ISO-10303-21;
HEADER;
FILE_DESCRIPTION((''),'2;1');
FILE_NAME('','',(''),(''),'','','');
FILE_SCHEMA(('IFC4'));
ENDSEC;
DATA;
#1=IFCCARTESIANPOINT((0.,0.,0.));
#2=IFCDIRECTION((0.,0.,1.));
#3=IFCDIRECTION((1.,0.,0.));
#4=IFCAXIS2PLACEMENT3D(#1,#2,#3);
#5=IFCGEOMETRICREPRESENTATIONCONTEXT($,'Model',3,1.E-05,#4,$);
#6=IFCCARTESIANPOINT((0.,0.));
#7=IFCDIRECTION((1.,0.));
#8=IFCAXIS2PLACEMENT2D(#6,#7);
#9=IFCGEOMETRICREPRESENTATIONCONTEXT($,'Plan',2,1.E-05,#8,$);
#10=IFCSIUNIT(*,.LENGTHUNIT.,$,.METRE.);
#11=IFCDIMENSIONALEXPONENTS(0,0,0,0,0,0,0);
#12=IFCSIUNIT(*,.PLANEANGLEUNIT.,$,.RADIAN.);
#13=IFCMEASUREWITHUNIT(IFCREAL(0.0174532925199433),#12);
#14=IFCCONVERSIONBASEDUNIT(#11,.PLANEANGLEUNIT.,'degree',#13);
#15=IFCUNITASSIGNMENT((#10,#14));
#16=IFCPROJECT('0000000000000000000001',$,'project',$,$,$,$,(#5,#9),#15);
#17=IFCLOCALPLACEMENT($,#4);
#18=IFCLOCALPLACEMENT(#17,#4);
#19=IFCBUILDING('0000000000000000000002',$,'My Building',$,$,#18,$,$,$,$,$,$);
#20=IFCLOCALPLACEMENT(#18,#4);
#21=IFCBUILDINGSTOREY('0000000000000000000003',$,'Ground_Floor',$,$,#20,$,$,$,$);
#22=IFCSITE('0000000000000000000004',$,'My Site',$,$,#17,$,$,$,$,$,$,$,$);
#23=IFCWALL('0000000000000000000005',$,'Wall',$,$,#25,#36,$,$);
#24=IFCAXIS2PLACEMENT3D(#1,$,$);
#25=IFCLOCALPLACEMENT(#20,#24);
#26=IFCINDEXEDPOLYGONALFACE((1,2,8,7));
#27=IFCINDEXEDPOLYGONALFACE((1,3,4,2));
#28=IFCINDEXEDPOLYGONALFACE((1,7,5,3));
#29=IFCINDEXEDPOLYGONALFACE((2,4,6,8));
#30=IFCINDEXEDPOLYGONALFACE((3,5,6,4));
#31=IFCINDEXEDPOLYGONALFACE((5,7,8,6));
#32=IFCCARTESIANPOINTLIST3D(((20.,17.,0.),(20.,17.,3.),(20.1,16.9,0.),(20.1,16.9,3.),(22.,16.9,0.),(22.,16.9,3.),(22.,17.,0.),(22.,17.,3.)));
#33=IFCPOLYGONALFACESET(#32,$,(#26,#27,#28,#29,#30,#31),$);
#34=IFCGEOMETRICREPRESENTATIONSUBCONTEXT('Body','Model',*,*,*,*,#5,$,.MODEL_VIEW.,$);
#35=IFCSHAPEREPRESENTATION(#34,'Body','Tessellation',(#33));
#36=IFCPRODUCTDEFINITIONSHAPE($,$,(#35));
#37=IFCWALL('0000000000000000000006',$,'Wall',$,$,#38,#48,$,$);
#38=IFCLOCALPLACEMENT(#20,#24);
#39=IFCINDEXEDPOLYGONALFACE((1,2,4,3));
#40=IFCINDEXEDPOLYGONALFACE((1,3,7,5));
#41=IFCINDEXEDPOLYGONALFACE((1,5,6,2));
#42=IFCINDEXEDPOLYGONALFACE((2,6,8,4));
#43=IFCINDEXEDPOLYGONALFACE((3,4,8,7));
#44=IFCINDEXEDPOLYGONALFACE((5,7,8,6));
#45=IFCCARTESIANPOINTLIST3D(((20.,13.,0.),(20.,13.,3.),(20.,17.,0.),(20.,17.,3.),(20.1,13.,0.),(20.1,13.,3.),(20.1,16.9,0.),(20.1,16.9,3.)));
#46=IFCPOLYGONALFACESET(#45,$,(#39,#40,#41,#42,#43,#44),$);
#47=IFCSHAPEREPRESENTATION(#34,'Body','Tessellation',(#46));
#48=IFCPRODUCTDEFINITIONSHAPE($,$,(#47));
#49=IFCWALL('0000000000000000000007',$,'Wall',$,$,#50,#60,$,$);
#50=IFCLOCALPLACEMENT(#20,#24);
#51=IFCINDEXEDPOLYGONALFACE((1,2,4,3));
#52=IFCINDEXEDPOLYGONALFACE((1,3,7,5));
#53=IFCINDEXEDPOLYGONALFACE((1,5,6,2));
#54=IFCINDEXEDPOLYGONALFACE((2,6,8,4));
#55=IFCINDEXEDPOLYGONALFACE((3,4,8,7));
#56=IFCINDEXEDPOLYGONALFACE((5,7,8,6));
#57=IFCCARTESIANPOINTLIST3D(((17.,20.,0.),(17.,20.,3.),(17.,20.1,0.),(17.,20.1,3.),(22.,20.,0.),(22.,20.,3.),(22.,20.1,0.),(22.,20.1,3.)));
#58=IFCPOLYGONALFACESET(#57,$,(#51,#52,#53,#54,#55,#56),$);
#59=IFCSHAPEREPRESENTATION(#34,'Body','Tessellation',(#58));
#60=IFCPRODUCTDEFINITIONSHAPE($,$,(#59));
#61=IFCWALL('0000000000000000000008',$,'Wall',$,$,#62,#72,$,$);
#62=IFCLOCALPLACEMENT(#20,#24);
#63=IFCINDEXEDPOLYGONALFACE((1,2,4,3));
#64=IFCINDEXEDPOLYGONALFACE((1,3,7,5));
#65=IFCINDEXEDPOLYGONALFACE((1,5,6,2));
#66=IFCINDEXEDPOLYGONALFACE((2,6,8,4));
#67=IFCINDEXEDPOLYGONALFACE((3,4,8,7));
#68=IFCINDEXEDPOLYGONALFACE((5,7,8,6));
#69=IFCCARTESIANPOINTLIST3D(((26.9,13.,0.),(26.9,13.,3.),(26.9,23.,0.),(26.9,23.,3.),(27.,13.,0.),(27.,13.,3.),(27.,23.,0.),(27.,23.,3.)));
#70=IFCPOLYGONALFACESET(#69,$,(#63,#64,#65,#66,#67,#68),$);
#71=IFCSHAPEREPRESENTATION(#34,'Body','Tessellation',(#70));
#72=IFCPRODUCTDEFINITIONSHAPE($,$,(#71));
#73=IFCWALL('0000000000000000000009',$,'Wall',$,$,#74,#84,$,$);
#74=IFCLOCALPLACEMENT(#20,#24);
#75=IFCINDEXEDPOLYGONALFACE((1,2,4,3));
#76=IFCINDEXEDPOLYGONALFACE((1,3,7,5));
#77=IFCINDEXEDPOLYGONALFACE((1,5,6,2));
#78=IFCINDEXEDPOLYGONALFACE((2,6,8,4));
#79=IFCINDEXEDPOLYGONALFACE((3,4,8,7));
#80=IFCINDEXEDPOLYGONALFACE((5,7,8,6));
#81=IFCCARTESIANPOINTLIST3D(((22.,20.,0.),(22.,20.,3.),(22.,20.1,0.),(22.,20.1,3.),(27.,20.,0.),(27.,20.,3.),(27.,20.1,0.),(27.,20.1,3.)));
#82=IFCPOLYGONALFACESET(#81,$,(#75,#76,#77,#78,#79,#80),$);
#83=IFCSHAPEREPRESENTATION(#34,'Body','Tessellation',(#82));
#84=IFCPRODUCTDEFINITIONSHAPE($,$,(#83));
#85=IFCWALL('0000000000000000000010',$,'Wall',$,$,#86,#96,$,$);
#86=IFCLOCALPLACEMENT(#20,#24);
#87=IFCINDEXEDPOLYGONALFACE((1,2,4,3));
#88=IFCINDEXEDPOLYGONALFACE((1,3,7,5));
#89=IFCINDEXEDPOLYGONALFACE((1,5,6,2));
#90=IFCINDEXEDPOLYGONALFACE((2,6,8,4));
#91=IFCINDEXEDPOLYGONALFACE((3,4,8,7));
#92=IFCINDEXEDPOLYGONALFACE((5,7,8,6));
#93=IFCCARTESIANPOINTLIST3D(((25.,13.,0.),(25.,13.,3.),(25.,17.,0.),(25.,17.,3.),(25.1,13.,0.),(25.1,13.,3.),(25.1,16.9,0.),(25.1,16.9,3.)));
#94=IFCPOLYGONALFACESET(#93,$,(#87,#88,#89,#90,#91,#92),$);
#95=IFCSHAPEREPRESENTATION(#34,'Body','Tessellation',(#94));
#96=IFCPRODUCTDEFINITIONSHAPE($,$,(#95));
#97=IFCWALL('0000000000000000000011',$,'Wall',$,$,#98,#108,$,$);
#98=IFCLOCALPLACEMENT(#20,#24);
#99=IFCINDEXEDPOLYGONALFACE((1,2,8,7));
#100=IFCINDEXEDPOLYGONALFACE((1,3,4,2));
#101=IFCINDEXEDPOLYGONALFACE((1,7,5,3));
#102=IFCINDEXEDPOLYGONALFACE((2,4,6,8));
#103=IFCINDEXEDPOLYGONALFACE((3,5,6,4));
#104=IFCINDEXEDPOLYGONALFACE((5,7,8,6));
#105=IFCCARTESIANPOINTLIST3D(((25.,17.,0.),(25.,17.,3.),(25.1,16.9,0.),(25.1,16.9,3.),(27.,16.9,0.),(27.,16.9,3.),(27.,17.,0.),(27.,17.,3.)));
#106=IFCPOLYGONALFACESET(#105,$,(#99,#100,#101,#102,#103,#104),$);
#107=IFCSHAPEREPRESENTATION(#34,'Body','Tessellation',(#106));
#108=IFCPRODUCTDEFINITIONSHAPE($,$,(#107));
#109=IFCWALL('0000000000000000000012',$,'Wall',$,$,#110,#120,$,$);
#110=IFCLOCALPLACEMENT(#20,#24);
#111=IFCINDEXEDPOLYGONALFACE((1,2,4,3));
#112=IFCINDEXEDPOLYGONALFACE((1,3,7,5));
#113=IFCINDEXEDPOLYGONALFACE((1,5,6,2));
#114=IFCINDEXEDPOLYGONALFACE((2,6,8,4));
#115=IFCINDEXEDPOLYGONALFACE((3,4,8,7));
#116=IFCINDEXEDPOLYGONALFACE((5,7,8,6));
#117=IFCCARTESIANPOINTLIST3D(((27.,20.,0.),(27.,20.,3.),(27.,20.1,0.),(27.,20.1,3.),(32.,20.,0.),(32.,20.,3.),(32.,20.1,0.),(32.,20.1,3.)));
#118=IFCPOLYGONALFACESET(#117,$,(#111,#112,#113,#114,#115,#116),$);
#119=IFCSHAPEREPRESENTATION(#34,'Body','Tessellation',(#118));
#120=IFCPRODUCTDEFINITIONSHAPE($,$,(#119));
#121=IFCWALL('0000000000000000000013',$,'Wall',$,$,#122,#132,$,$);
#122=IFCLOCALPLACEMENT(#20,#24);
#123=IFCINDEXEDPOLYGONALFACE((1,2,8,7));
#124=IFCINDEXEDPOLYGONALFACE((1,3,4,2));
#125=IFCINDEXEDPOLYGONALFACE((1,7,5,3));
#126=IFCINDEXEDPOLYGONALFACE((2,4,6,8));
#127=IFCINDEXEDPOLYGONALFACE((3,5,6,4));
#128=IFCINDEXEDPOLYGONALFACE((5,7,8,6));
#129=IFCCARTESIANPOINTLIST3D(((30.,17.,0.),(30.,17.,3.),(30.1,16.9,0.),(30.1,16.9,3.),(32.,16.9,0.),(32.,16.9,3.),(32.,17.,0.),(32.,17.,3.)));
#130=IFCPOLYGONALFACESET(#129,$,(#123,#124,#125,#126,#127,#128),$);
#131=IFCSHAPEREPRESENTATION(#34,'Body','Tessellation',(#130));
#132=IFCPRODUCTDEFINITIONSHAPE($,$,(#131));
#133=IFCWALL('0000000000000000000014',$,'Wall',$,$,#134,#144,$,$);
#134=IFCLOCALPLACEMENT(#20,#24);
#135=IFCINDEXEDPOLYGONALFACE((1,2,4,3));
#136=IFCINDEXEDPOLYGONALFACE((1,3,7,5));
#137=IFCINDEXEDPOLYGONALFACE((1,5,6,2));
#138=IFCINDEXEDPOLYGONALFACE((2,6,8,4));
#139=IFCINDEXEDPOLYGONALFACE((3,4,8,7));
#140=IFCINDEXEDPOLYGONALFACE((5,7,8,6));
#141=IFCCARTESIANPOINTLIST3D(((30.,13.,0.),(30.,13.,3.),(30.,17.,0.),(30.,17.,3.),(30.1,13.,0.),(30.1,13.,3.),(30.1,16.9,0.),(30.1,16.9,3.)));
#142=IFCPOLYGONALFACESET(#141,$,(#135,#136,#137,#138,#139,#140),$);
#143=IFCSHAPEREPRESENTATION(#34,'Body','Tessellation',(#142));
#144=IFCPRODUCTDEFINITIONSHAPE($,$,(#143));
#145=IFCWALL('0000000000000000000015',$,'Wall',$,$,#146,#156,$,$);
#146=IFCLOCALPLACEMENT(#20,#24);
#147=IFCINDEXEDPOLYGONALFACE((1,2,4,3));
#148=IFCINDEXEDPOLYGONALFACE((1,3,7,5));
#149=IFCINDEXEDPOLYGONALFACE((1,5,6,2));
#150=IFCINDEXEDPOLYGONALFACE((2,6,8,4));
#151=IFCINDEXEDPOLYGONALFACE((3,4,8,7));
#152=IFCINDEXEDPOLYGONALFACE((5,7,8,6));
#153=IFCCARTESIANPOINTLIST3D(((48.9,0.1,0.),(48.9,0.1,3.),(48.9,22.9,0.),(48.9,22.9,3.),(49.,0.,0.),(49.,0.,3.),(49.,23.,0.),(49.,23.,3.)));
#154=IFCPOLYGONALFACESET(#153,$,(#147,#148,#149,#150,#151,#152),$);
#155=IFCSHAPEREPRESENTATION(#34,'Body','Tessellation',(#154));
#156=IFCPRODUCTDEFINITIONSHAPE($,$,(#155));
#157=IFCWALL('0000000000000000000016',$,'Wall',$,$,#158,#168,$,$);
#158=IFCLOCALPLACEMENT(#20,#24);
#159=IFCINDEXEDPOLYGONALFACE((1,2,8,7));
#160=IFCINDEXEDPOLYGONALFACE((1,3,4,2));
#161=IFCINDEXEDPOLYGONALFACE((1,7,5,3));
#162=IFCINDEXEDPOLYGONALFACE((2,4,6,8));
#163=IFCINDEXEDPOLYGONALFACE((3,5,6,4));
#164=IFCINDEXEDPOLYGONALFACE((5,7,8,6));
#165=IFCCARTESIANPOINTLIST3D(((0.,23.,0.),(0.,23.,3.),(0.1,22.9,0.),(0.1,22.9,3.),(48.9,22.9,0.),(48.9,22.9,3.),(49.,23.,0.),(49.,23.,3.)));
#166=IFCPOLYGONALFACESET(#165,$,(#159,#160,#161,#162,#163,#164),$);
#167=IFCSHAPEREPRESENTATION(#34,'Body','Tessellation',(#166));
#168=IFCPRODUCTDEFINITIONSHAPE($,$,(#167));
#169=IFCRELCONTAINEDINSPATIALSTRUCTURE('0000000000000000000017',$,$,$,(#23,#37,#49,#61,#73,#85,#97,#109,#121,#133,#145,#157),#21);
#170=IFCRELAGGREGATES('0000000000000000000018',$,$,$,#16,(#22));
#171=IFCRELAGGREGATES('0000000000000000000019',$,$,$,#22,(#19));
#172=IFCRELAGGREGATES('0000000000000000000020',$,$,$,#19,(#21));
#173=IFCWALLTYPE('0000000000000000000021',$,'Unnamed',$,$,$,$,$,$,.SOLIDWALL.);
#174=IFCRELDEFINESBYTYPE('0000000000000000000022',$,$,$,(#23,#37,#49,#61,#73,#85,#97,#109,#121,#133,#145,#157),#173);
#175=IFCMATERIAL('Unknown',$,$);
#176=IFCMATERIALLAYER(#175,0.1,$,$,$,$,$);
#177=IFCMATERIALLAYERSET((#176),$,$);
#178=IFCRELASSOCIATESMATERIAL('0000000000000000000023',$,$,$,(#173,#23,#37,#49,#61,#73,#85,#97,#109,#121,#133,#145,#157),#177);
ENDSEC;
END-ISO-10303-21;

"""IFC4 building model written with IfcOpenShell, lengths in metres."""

from ifc_helpers import new_model, entity, si_unit, converted_unit, frame, origin_with_axes, origin_2d_with_axis, place, context, subcontext, project, spatial, line, indexed_curve, outline, extrude, material, layer, layer_set, layer_usage, type_object, element, save


model = new_model("IFC4")

# Units and contexts
model_context = context("Model", 3, precision=1e-05, world=origin_with_axes())
plan_context = context("Plan", 2, precision=1e-05, world=origin_2d_with_axis())
body_context = subcontext(model_context, "Body", "Model", "MODEL_VIEW")
ifc_project = project(units=[si_unit("LENGTHUNIT", "METRE"), converted_unit("PLANEANGLEUNIT", "degree", entity("IfcReal", 0.0174532925199433), si_unit("PLANEANGLEUNIT", "RADIAN"), dimensions=[0, 0, 0, 0, 0, 0, 0])], contexts=[model_context, plan_context])

# Site, building, storey
site_placement = place(None, origin_with_axes())
site = spatial("IfcSite", under=ifc_project, at=site_placement, Name="My Site")
building_placement = place(site_placement, origin_with_axes())
building = spatial("IfcBuilding", under=site, at=building_placement, Name="My Building")
storey_placement = place(building_placement, origin_with_axes())
storey = spatial("IfcBuildingStorey", under=building, at=storey_placement, Name="Ground_Floor")

# Walls
ifc_material = material(Name="Unknown")
ifc_layer = layer(ifc_material, 0.1)
ifc_layer_set = layer_set([ifc_layer])
wall_type = type_object("IfcWallType", Name="Unnamed", PredefinedType="SOLIDWALL", material=ifc_layer_set)
ifc_layer_usage_1 = layer_usage(ifc_layer_set, "AXIS2", "POSITIVE", 0.0)
wall_1_placement = place(storey_placement, frame((22.0, 17.0, 0.0), z_axis=(0.0, 0.0, 1.0), x_axis=(-1.0, 0.0, 0.0)))
element("IfcWall", 1, at=wall_1_placement, inside=storey, type_object=wall_type, material=ifc_layer_usage_1, Name="Wall", context=body_context, shape_type="SweptSolid", body=[
    extrude(outline(indexed_curve([(0.0, 0.0), (0.0, 0.1), (1.9, 0.1), (2.0, 0.0)], segments=[line(1, 2, 3, 4, 1)])), origin_with_axes(), (0.0, 0.0, 1.0), 3.0),
])
ifc_layer_usage_2 = layer_usage(ifc_layer_set, "AXIS2", "POSITIVE", 0.0)
wall_2_placement = place(storey_placement, frame((20.0, 17.0, 0.0), z_axis=(0.0, 0.0, 1.0), x_axis=(0.0, -1.0, 0.0)))
element("IfcWall", 2, at=wall_2_placement, inside=storey, type_object=wall_type, material=ifc_layer_usage_2, Name="Wall", context=body_context, shape_type="SweptSolid", body=[
    extrude(outline(indexed_curve([(0.0, 0.0), (0.1, 0.1), (4.0, 0.1), (4.0, 0.0)], segments=[line(1, 2, 3, 4, 1)])), origin_with_axes(), (0.0, 0.0, 1.0), 3.0),
])
ifc_layer_usage_3 = layer_usage(ifc_layer_set, "AXIS2", "POSITIVE", 0.0)
wall_3_placement = place(storey_placement, frame((17.0, 20.0, 0.0), z_axis=(0.0, 0.0, 1.0), x_axis=(1.0, 0.0, 0.0)))
element("IfcWall", 3, at=wall_3_placement, inside=storey, type_object=wall_type, material=ifc_layer_usage_3, Name="Wall", context=body_context, shape_type="SweptSolid", body=[
    extrude(outline(indexed_curve([(0.0, 0.0), (0.0, 0.1), (5.0, 0.1), (5.0, 0.0)], segments=[line(1, 2, 3, 4, 1)])), origin_with_axes(), (0.0, 0.0, 1.0), 3.0),
])
ifc_layer_usage_4 = layer_usage(ifc_layer_set, "AXIS2", "POSITIVE", 0.0)
wall_4_placement = place(storey_placement, frame((27.0, 13.0, 0.0), z_axis=(0.0, 0.0, 1.0), x_axis=(0.0, 1.0, 0.0)))
element("IfcWall", 4, at=wall_4_placement, inside=storey, type_object=wall_type, material=ifc_layer_usage_4, Name="Wall", context=body_context, shape_type="SweptSolid", body=[
    extrude(outline(indexed_curve([(0.0, 0.0), (0.0, 0.1), (10.0, 0.1), (10.0, 0.0)], segments=[line(1, 2, 3, 4, 1)])), origin_with_axes(), (0.0, 0.0, 1.0), 3.0),
])
ifc_layer_usage_5 = layer_usage(ifc_layer_set, "AXIS2", "POSITIVE", 0.0)
wall_5_placement = place(storey_placement, frame((22.0, 20.0, 0.0), z_axis=(0.0, 0.0, 1.0), x_axis=(1.0, 0.0, 0.0)))
element("IfcWall", 5, at=wall_5_placement, inside=storey, type_object=wall_type, material=ifc_layer_usage_5, Name="Wall", context=body_context, shape_type="SweptSolid", body=[
    extrude(outline(indexed_curve([(0.0, 0.0), (0.0, 0.1), (5.0, 0.1), (5.0, 0.0)], segments=[line(1, 2, 3, 4, 1)])), origin_with_axes(), (0.0, 0.0, 1.0), 3.0),
])
ifc_layer_usage_6 = layer_usage(ifc_layer_set, "AXIS2", "POSITIVE", 0.0)
wall_6_placement = place(storey_placement, frame((25.0, 17.0, 0.0), z_axis=(0.0, 0.0, 1.0), x_axis=(0.0, -1.0, 0.0)))
element("IfcWall", 6, at=wall_6_placement, inside=storey, type_object=wall_type, material=ifc_layer_usage_6, Name="Wall", context=body_context, shape_type="SweptSolid", body=[
    extrude(outline(indexed_curve([(0.0, 0.0), (0.1, 0.1), (4.0, 0.1), (4.0, 0.0)], segments=[line(1, 2, 3, 4, 1)])), origin_with_axes(), (0.0, 0.0, 1.0), 3.0),
])
ifc_layer_usage_7 = layer_usage(ifc_layer_set, "AXIS2", "POSITIVE", 0.0)
wall_7_placement = place(storey_placement, frame((27.0, 17.0, 0.0), z_axis=(0.0, 0.0, 1.0), x_axis=(-1.0, 0.0, 0.0)))
element("IfcWall", 7, at=wall_7_placement, inside=storey, type_object=wall_type, material=ifc_layer_usage_7, Name="Wall", context=body_context, shape_type="SweptSolid", body=[
    extrude(outline(indexed_curve([(0.0, 0.0), (0.0, 0.1), (1.9, 0.1), (2.0, 0.0)], segments=[line(1, 2, 3, 4, 1)])), origin_with_axes(), (0.0, 0.0, 1.0), 3.0),
])
ifc_layer_usage_8 = layer_usage(ifc_layer_set, "AXIS2", "POSITIVE", 0.0)
wall_8_placement = place(storey_placement, frame((27.0, 20.0, 0.0), z_axis=(0.0, 0.0, 1.0), x_axis=(1.0, 0.0, 0.0)))
element("IfcWall", 8, at=wall_8_placement, inside=storey, type_object=wall_type, material=ifc_layer_usage_8, Name="Wall", context=body_context, shape_type="SweptSolid", body=[
    extrude(outline(indexed_curve([(0.0, 0.0), (0.0, 0.1), (5.0, 0.1), (5.0, 0.0)], segments=[line(1, 2, 3, 4, 1)])), origin_with_axes(), (0.0, 0.0, 1.0), 3.0),
])
ifc_layer_usage_9 = layer_usage(ifc_layer_set, "AXIS2", "POSITIVE", 0.0)
wall_9_placement = place(storey_placement, frame((32.0, 17.0, 0.0), z_axis=(0.0, 0.0, 1.0), x_axis=(-1.0, 0.0, 0.0)))
element("IfcWall", 9, at=wall_9_placement, inside=storey, type_object=wall_type, material=ifc_layer_usage_9, Name="Wall", context=body_context, shape_type="SweptSolid", body=[
    extrude(outline(indexed_curve([(0.0, 0.0), (0.0, 0.1), (1.9, 0.1), (2.0, 0.0)], segments=[line(1, 2, 3, 4, 1)])), origin_with_axes(), (0.0, 0.0, 1.0), 3.0),
])
ifc_layer_usage_10 = layer_usage(ifc_layer_set, "AXIS2", "POSITIVE", 0.0)
wall_10_placement = place(storey_placement, frame((30.0, 17.0, 0.0), z_axis=(0.0, 0.0, 1.0), x_axis=(0.0, -1.0, 0.0)))
element("IfcWall", 10, at=wall_10_placement, inside=storey, type_object=wall_type, material=ifc_layer_usage_10, Name="Wall", context=body_context, shape_type="SweptSolid", body=[
    extrude(outline(indexed_curve([(0.0, 0.0), (0.1, 0.1), (4.0, 0.1), (4.0, 0.0)], segments=[line(1, 2, 3, 4, 1)])), origin_with_axes(), (0.0, 0.0, 1.0), 3.0),
])
ifc_layer_usage_11 = layer_usage(ifc_layer_set, "AXIS2", "POSITIVE", 0.0)
wall_11_placement = place(storey_placement, frame((49.0, 0.0, 0.0), z_axis=(0.0, 0.0, 1.0), x_axis=(0.0, 1.0, 0.0)))
element("IfcWall", 11, at=wall_11_placement, inside=storey, type_object=wall_type, material=ifc_layer_usage_11, Name="Wall", context=body_context, shape_type="SweptSolid", body=[
    extrude(outline(indexed_curve([(0.0, 0.0), (0.1, 0.1), (22.9, 0.1), (23.0, 0.0)], segments=[line(1, 2, 3, 4, 1)])), origin_with_axes(), (0.0, 0.0, 1.0), 3.0),
])
ifc_layer_usage_12 = layer_usage(ifc_layer_set, "AXIS2", "POSITIVE", 0.0)
wall_12_placement = place(storey_placement, frame((49.0, 23.0, 0.0), z_axis=(0.0, 0.0, 1.0), x_axis=(-1.0, 0.0, 0.0)))
element("IfcWall", 12, at=wall_12_placement, inside=storey, type_object=wall_type, material=ifc_layer_usage_12, Name="Wall", context=body_context, shape_type="SweptSolid", body=[
    extrude(outline(indexed_curve([(0.0, 0.0), (0.1, 0.1), (48.9, 0.1), (49.0, 0.0)], segments=[line(1, 2, 3, 4, 1)])), origin_with_axes(), (0.0, 0.0, 1.0), 3.0),
])

save(model, "model.ifc")
